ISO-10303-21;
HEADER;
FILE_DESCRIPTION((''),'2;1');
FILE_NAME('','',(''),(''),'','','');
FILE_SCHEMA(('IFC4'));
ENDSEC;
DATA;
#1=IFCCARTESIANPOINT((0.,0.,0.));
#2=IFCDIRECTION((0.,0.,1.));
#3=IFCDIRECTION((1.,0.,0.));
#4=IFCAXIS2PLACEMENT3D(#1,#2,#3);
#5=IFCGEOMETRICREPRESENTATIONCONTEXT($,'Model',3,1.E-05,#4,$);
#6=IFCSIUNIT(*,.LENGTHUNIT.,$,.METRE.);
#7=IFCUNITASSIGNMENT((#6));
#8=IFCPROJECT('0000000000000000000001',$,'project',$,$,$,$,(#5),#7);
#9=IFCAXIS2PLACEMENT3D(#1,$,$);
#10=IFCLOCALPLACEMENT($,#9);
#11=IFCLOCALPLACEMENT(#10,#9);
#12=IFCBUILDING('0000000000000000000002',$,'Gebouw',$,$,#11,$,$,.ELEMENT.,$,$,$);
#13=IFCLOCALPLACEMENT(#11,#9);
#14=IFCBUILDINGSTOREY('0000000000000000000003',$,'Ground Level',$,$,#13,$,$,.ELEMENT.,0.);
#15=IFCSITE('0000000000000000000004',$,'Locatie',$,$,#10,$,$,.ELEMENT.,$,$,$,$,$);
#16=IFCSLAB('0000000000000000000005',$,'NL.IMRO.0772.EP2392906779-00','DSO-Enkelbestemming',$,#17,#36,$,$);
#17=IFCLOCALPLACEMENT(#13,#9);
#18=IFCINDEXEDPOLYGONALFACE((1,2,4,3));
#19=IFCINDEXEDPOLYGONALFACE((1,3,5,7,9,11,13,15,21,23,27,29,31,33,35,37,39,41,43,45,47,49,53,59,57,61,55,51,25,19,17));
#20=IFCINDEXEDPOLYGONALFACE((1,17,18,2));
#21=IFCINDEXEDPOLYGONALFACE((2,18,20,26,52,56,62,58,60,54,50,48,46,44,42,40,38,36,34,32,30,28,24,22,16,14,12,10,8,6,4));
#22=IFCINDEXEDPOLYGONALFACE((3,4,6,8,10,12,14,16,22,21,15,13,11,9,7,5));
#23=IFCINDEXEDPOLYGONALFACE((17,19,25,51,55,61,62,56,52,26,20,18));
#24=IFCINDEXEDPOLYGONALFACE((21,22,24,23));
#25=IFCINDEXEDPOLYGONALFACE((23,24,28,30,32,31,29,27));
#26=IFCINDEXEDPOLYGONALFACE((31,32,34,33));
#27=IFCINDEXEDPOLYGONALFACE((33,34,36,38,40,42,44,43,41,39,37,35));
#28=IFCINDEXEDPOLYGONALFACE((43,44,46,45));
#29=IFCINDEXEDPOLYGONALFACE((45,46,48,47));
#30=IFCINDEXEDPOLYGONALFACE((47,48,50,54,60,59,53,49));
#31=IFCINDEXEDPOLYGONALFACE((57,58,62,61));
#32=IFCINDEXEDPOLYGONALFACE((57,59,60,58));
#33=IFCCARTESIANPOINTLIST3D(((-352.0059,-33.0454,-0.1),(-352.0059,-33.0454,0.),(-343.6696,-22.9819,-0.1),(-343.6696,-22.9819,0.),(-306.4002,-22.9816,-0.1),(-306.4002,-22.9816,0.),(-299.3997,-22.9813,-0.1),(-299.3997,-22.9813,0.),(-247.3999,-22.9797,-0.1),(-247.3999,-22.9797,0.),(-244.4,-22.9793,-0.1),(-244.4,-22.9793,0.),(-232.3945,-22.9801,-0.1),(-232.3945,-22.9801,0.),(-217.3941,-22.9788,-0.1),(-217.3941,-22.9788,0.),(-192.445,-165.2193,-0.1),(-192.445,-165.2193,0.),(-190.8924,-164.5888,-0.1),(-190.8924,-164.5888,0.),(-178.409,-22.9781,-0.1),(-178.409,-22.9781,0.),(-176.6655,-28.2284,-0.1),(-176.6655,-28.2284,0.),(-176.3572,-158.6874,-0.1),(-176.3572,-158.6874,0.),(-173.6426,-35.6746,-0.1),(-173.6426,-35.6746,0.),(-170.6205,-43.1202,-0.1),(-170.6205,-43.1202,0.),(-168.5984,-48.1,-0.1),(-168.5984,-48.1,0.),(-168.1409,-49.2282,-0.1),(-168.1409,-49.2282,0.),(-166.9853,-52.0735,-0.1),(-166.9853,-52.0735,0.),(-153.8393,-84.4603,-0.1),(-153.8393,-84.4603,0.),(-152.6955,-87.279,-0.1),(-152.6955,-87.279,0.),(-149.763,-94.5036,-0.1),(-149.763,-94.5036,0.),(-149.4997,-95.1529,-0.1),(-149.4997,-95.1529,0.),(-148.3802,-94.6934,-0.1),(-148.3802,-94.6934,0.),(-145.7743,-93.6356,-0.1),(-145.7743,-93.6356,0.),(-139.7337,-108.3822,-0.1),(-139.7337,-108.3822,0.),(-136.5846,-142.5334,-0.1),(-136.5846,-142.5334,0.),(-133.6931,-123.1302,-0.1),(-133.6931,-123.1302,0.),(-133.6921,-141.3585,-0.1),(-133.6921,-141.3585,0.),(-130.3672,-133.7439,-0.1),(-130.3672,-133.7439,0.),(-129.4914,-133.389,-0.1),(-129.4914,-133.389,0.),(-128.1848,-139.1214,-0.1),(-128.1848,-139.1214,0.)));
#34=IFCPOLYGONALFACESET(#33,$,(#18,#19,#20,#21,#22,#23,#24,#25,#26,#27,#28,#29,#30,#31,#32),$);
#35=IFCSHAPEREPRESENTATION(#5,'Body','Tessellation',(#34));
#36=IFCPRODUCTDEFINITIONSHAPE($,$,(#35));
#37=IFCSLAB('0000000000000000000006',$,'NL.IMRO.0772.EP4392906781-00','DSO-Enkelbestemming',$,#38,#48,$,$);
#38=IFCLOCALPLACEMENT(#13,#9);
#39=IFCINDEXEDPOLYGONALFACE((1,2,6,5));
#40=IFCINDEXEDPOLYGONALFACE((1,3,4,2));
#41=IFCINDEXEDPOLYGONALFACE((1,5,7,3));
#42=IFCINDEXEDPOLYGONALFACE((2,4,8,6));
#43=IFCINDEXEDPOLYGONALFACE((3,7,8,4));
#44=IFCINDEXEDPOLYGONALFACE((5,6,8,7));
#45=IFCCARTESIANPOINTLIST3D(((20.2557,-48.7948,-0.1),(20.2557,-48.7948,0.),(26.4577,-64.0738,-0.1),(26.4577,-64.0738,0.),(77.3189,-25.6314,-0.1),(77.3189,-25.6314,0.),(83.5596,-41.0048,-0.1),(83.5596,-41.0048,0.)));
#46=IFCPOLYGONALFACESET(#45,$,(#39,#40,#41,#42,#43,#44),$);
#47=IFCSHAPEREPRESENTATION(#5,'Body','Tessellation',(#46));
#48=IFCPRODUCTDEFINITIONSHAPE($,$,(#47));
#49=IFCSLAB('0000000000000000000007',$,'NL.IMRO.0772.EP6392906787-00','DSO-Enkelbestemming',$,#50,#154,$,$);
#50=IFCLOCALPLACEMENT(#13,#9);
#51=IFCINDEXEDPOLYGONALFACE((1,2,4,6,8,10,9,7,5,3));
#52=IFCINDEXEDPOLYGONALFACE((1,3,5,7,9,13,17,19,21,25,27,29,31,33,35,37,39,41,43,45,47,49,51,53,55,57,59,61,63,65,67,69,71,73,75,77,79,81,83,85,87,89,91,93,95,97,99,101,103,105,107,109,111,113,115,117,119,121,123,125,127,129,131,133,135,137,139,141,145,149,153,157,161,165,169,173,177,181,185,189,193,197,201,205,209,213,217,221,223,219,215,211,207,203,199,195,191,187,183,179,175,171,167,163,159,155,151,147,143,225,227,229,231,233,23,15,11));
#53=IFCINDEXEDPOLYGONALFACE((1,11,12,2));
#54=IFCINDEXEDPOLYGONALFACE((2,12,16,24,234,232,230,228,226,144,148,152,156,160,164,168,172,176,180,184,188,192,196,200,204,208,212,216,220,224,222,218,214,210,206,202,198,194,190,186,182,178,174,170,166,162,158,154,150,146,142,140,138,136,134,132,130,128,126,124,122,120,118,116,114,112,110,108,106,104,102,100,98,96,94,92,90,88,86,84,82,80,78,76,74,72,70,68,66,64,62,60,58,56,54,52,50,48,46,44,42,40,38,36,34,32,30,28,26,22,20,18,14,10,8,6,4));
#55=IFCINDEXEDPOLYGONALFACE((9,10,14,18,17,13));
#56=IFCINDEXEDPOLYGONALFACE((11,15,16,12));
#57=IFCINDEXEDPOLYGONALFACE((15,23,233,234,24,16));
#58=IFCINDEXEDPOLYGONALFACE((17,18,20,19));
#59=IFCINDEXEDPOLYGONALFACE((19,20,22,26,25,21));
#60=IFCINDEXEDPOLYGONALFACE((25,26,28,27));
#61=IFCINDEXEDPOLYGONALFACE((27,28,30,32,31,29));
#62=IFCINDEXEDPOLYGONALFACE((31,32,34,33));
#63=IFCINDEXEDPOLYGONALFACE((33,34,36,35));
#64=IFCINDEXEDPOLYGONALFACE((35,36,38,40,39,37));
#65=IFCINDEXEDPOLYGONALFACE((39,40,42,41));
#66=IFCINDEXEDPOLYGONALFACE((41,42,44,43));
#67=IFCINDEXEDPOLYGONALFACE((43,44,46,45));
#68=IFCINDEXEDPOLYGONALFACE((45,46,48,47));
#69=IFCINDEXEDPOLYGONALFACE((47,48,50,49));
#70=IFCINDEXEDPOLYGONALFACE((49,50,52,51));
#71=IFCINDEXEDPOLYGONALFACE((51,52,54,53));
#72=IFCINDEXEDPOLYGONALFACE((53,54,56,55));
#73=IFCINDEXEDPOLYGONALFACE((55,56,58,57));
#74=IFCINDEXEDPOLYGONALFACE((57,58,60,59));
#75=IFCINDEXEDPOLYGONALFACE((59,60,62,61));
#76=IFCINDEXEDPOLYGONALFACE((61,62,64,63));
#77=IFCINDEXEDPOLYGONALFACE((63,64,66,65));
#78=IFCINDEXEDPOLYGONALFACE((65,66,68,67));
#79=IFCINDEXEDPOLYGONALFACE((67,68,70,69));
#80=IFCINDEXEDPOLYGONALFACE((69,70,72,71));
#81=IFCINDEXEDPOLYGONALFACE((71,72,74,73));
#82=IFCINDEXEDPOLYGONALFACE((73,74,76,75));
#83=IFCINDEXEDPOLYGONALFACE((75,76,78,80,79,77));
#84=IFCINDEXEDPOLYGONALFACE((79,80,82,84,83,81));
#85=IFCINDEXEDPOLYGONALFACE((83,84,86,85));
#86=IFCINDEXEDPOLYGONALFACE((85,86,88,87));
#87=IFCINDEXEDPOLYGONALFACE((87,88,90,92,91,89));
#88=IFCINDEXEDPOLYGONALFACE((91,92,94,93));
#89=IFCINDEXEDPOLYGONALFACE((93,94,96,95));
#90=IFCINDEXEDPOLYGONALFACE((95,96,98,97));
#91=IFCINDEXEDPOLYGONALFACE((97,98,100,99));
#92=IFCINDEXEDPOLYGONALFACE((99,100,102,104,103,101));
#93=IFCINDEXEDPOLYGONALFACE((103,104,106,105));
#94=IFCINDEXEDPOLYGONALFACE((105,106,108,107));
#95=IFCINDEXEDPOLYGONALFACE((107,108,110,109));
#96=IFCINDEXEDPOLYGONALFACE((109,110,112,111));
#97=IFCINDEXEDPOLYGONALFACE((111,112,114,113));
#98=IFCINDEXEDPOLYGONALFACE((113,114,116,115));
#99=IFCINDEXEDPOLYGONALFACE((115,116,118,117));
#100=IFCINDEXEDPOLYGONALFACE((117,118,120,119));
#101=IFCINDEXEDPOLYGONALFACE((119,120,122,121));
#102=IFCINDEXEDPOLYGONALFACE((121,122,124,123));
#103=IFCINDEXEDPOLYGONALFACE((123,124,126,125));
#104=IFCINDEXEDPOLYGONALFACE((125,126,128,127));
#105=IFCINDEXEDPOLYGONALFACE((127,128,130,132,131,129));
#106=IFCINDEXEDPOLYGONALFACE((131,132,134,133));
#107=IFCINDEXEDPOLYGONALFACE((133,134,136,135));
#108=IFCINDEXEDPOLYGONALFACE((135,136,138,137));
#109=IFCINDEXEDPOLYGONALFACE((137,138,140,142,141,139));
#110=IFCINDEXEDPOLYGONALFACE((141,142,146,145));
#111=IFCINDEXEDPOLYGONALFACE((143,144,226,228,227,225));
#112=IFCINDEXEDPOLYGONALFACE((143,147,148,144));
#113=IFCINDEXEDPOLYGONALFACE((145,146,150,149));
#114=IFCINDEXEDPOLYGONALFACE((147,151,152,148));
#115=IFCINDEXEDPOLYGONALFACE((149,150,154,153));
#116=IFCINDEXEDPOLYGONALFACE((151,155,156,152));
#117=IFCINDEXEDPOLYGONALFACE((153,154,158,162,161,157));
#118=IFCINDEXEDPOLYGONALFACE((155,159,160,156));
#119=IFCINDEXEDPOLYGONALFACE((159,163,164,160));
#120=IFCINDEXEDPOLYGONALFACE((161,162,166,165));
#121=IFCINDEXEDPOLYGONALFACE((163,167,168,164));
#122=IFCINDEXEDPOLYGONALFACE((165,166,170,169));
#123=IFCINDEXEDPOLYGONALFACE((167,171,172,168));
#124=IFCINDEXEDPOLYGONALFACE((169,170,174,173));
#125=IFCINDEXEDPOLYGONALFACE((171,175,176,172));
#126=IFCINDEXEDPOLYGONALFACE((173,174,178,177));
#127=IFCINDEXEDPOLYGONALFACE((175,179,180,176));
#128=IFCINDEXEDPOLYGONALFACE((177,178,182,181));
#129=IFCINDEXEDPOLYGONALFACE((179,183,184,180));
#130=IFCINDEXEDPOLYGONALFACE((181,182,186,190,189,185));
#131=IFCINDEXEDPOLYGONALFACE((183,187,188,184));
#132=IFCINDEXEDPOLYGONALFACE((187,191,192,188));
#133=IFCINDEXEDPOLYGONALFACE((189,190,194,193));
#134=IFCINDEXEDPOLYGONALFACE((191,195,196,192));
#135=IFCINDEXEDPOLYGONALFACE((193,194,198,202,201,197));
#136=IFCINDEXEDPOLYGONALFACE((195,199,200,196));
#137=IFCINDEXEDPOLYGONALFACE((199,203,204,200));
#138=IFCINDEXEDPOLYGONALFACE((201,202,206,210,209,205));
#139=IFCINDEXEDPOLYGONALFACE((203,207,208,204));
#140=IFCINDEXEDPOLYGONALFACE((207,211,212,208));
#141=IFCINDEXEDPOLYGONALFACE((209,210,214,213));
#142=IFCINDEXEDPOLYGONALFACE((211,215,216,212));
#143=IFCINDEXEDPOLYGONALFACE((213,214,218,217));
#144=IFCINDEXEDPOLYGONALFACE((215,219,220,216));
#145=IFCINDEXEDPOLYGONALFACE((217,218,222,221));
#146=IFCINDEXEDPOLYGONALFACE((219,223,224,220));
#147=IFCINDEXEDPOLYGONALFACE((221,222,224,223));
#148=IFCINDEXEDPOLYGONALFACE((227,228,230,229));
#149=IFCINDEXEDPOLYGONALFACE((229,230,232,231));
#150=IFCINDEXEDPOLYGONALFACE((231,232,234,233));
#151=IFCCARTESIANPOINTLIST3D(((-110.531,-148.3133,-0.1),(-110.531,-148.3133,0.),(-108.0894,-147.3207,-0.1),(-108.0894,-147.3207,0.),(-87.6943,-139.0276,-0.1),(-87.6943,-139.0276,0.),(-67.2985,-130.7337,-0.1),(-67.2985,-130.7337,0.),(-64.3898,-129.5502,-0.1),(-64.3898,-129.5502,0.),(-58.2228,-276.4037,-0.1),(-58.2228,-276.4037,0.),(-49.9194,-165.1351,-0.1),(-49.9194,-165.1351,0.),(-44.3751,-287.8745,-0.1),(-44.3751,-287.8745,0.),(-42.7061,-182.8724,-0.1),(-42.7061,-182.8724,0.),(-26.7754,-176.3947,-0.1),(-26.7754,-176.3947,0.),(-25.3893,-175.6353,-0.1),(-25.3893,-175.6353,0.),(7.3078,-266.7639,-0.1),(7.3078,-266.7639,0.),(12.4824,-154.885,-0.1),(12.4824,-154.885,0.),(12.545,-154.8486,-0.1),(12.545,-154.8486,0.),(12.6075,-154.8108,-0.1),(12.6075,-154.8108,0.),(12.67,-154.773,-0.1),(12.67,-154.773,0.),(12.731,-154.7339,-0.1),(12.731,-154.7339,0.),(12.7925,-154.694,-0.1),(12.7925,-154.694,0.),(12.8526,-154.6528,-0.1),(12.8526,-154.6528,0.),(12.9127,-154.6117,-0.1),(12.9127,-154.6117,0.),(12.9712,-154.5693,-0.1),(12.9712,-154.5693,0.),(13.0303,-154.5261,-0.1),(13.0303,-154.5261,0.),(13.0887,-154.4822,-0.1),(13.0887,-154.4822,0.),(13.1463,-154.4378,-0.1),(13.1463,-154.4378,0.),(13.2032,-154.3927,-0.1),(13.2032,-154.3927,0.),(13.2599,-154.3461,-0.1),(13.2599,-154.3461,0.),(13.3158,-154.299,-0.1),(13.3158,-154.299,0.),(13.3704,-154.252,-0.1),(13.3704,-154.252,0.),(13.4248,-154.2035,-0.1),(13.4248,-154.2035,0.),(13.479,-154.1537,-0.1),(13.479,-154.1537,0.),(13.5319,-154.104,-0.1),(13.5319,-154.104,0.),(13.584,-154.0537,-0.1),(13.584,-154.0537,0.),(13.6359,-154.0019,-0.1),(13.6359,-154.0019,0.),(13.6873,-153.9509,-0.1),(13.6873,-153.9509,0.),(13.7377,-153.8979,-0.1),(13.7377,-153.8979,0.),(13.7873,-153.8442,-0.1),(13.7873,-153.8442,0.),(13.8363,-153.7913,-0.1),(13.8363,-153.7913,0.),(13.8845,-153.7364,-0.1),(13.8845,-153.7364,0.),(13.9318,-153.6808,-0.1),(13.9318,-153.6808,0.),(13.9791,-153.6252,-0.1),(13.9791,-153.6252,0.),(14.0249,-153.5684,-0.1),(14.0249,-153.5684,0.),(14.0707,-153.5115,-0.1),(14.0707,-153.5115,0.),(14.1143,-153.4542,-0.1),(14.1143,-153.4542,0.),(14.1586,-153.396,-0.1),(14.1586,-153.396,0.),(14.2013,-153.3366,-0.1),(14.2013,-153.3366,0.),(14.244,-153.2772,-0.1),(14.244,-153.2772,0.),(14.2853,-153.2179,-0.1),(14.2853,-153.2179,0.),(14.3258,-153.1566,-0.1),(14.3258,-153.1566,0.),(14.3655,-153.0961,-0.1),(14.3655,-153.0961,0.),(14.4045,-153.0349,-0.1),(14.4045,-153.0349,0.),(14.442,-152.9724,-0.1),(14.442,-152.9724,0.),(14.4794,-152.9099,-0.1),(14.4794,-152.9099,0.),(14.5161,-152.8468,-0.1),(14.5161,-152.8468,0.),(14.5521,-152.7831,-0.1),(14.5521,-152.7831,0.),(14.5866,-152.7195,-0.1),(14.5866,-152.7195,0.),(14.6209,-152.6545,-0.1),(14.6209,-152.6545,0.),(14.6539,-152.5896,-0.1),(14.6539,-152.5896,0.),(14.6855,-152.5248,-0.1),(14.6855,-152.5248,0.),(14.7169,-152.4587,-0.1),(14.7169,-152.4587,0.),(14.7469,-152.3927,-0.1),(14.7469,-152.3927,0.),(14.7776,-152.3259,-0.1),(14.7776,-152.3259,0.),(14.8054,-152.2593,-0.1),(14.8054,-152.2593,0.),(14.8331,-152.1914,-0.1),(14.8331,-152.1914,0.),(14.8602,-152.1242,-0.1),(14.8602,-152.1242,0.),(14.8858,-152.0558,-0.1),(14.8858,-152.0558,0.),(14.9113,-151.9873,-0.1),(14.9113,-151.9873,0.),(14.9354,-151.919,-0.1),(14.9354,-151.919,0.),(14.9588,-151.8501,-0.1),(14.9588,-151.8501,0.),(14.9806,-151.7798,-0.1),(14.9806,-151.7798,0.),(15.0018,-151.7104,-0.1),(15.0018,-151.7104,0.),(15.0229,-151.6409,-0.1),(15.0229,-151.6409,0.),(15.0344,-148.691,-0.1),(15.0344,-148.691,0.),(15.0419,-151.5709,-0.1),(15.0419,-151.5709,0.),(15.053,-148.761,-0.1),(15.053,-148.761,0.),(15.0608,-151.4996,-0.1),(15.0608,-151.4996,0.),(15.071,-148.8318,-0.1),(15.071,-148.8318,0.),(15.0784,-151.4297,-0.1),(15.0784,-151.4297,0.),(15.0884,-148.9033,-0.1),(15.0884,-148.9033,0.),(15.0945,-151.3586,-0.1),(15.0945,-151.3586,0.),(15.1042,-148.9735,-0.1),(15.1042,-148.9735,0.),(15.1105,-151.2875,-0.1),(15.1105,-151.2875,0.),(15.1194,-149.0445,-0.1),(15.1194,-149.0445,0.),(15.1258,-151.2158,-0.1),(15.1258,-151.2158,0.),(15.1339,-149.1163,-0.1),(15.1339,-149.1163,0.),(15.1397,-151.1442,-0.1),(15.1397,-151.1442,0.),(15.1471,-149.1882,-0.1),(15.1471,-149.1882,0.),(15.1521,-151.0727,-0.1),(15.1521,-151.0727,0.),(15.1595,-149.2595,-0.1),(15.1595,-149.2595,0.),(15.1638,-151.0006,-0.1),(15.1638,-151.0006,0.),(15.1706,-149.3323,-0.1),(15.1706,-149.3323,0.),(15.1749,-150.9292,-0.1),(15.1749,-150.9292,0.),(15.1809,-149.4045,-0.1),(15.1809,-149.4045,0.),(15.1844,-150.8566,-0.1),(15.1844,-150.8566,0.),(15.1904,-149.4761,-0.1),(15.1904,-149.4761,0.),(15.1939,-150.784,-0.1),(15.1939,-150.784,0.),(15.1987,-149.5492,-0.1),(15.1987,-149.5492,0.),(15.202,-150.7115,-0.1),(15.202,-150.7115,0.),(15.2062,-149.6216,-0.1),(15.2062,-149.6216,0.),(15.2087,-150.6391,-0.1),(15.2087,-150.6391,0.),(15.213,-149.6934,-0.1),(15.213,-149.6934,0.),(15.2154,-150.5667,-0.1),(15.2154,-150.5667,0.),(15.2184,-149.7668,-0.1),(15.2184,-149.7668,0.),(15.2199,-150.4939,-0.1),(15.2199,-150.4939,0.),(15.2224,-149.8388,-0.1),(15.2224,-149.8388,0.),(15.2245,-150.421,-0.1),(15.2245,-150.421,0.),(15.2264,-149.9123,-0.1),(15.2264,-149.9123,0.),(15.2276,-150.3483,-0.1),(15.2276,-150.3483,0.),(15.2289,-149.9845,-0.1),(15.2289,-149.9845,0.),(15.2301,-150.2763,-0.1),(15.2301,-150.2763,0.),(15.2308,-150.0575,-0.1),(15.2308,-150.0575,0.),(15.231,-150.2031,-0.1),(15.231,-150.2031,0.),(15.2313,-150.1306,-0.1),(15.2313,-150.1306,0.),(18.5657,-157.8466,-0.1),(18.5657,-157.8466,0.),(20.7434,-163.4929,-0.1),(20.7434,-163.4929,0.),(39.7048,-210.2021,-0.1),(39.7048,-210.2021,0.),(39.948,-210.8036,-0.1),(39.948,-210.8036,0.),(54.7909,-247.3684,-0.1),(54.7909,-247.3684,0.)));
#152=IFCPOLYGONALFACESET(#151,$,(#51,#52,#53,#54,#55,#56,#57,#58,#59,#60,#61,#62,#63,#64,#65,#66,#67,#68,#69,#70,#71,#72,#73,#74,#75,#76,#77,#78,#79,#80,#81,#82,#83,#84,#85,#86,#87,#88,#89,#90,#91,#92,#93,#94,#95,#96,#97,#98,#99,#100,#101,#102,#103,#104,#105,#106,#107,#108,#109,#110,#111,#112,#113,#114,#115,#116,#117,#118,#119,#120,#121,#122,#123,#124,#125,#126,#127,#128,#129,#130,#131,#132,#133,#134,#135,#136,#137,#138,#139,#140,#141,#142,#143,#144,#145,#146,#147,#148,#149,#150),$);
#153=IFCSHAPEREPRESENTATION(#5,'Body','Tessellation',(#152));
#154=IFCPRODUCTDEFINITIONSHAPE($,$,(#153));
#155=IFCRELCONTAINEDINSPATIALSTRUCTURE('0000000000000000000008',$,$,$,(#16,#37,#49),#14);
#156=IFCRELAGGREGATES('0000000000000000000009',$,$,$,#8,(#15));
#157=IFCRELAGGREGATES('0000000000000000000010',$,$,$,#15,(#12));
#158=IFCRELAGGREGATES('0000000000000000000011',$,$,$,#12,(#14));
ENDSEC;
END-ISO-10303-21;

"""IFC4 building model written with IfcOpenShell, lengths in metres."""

from ifc_helpers import new_model, si_unit, frame, origin, origin_with_axes, place, context, project, spatial, polyline, outline, extrude, element, save


model = new_model("IFC4")

# Units and contexts
model_context = context("Model", 3, precision=1e-05, world=origin_with_axes())
ifc_project = project(units=[si_unit("LENGTHUNIT", "METRE")], contexts=[model_context])

# Site, building, storey
site_placement = place(None, origin())
site = spatial("IfcSite", under=ifc_project, at=site_placement, Name="Locatie", CompositionType="ELEMENT")
building_placement = place(site_placement, origin())
building = spatial("IfcBuilding", under=site, at=building_placement, Name="Gebouw", CompositionType="ELEMENT")
storey_placement = place(building_placement, origin())
storey = spatial("IfcBuildingStorey", under=building, at=storey_placement, Name="Ground Level", CompositionType="ELEMENT", Elevation=0.0)

# Slabs
slab_1_placement = place(storey_placement, origin())
element("IfcSlab", 1, at=slab_1_placement, inside=storey, Name="NL.IMRO.0772.EP2392906779-00", Description="DSO-Enkelbestemming", context=model_context, shape_type="SweptSolid", body=[
    extrude(outline(polyline([(-306.4002, -22.9816), (-299.3997, -22.9813), (-247.3999, -22.9797), (-244.4, -22.9793), (-232.3945, -22.9801), (-217.3941, -22.9788), (-178.409, -22.9781), (-176.6655, -28.2284), (-173.6426, -35.6746), (-170.6205, -43.1202), (-168.5984, -48.1), (-168.1409, -49.2282), (-166.9853, -52.0735), (-153.8393, -84.4603), (-152.6955, -87.279), (-149.763, -94.5036), (-149.4997, -95.1529), (-148.3802, -94.6934), (-145.7743, -93.6356), (-139.7337, -108.3822), (-133.6931, -123.1302), (-129.4914, -133.389), (-130.3672, -133.7439), (-128.1848, -139.1214), (-133.6921, -141.3585), (-136.5846, -142.5334), (-176.3572, -158.6874), (-190.8924, -164.5888), (-192.445, -165.2193), (-352.0059, -33.0454), (-343.6696, -22.9819), (-306.4002, -22.9816)])), frame((0.0, 0.0, -0.1), z_axis=(0.0, 0.0, 1.0), x_axis=(1.0, 0.0, 0.0)), (0.0, 0.0, 1.0), 0.1),
])
slab_2_placement = place(storey_placement, origin())
element("IfcSlab", 2, at=slab_2_placement, inside=storey, Name="NL.IMRO.0772.EP4392906781-00", Description="DSO-Enkelbestemming", context=model_context, shape_type="SweptSolid", body=[
    extrude(outline(polyline([(77.3189, -25.6314), (83.5596, -41.0048), (26.4577, -64.0738), (20.2557, -48.7948), (77.3189, -25.6314)])), frame((0.0, 0.0, -0.1), z_axis=(0.0, 0.0, 1.0), x_axis=(1.0, 0.0, 0.0)), (0.0, 0.0, 1.0), 0.1),
])
slab_3_placement = place(storey_placement, origin())
element("IfcSlab", 3, at=slab_3_placement, inside=storey, Name="NL.IMRO.0772.EP6392906787-00", Description="DSO-Enkelbestemming", context=model_context, shape_type="SweptSolid", body=[
    extrude(outline(polyline([(-110.531, -148.3133), (-108.0894, -147.3207), (-87.6943, -139.0276), (-67.2985, -130.7337), (-64.3898, -129.5502), (-49.9194, -165.1351), (-42.7061, -182.8724), (-26.7754, -176.3947), (-25.3893, -175.6353), (12.4824, -154.885), (12.545, -154.8486), (12.6075, -154.8108), (12.67, -154.773), (12.731, -154.7339), (12.7925, -154.694), (12.8526, -154.6528), (12.9127, -154.6117), (12.9712, -154.5693), (13.0303, -154.5261), (13.0887, -154.4822), (13.1463, -154.4378), (13.2032, -154.3927), (13.2599, -154.3461), (13.3158, -154.299), (13.3704, -154.252), (13.4248, -154.2035), (13.479, -154.1537), (13.5319, -154.104), (13.584, -154.0537), (13.6359, -154.0019), (13.6873, -153.9509), (13.7377, -153.8979), (13.7873, -153.8442), (13.8363, -153.7913), (13.8845, -153.7364), (13.9318, -153.6808), (13.9791, -153.6252), (14.0249, -153.5684), (14.0707, -153.5115), (14.1143, -153.4542), (14.1586, -153.396), (14.2013, -153.3366), (14.244, -153.2772), (14.2853, -153.2179), (14.3258, -153.1566), (14.3655, -153.0961), (14.4045, -153.0349), (14.442, -152.9724), (14.4794, -152.9099), (14.5161, -152.8468), (14.5521, -152.7831), (14.5866, -152.7195), (14.6209, -152.6545), (14.6539, -152.5896), (14.6855, -152.5248), (14.7169, -152.4587), (14.7469, -152.3927), (14.7776, -152.3259), (14.8054, -152.2593), (14.8331, -152.1914), (14.8602, -152.1242), (14.8858, -152.0558), (14.9113, -151.9873), (14.9354, -151.919), (14.9588, -151.8501), (14.9806, -151.7798), (15.0018, -151.7104), (15.0229, -151.6409), (15.0419, -151.5709), (15.0608, -151.4996), (15.0784, -151.4297), (15.0945, -151.3586), (15.1105, -151.2875), (15.1258, -151.2158), (15.1397, -151.1442), (15.1521, -151.0727), (15.1638, -151.0006), (15.1749, -150.9292), (15.1844, -150.8566), (15.1939, -150.784), (15.202, -150.7115), (15.2087, -150.6391), (15.2154, -150.5667), (15.2199, -150.4939), (15.2245, -150.421), (15.2276, -150.3483), (15.2301, -150.2763), (15.231, -150.2031), (15.2313, -150.1306), (15.2308, -150.0575), (15.2289, -149.9845), (15.2264, -149.9123), (15.2224, -149.8388), (15.2184, -149.7668), (15.213, -149.6934), (15.2062, -149.6216), (15.1987, -149.5492), (15.1904, -149.4761), (15.1809, -149.4045), (15.1706, -149.3323), (15.1595, -149.2595), (15.1471, -149.1882), (15.1339, -149.1163), (15.1194, -149.0445), (15.1042, -148.9735), (15.0884, -148.9033), (15.071, -148.8318), (15.053, -148.761), (15.0344, -148.691), (18.5657, -157.8466), (20.7434, -163.4929), (39.7048, -210.2021), (39.948, -210.8036), (54.7909, -247.3684), (7.3078, -266.7639), (-44.3751, -287.8745), (-58.2228, -276.4037), (-110.531, -148.3133)])), frame((0.0, 0.0, -0.1), z_axis=(0.0, 0.0, 1.0), x_axis=(1.0, 0.0, 0.0)), (0.0, 0.0, 1.0), 0.1),
])

save(model, "model.ifc")
